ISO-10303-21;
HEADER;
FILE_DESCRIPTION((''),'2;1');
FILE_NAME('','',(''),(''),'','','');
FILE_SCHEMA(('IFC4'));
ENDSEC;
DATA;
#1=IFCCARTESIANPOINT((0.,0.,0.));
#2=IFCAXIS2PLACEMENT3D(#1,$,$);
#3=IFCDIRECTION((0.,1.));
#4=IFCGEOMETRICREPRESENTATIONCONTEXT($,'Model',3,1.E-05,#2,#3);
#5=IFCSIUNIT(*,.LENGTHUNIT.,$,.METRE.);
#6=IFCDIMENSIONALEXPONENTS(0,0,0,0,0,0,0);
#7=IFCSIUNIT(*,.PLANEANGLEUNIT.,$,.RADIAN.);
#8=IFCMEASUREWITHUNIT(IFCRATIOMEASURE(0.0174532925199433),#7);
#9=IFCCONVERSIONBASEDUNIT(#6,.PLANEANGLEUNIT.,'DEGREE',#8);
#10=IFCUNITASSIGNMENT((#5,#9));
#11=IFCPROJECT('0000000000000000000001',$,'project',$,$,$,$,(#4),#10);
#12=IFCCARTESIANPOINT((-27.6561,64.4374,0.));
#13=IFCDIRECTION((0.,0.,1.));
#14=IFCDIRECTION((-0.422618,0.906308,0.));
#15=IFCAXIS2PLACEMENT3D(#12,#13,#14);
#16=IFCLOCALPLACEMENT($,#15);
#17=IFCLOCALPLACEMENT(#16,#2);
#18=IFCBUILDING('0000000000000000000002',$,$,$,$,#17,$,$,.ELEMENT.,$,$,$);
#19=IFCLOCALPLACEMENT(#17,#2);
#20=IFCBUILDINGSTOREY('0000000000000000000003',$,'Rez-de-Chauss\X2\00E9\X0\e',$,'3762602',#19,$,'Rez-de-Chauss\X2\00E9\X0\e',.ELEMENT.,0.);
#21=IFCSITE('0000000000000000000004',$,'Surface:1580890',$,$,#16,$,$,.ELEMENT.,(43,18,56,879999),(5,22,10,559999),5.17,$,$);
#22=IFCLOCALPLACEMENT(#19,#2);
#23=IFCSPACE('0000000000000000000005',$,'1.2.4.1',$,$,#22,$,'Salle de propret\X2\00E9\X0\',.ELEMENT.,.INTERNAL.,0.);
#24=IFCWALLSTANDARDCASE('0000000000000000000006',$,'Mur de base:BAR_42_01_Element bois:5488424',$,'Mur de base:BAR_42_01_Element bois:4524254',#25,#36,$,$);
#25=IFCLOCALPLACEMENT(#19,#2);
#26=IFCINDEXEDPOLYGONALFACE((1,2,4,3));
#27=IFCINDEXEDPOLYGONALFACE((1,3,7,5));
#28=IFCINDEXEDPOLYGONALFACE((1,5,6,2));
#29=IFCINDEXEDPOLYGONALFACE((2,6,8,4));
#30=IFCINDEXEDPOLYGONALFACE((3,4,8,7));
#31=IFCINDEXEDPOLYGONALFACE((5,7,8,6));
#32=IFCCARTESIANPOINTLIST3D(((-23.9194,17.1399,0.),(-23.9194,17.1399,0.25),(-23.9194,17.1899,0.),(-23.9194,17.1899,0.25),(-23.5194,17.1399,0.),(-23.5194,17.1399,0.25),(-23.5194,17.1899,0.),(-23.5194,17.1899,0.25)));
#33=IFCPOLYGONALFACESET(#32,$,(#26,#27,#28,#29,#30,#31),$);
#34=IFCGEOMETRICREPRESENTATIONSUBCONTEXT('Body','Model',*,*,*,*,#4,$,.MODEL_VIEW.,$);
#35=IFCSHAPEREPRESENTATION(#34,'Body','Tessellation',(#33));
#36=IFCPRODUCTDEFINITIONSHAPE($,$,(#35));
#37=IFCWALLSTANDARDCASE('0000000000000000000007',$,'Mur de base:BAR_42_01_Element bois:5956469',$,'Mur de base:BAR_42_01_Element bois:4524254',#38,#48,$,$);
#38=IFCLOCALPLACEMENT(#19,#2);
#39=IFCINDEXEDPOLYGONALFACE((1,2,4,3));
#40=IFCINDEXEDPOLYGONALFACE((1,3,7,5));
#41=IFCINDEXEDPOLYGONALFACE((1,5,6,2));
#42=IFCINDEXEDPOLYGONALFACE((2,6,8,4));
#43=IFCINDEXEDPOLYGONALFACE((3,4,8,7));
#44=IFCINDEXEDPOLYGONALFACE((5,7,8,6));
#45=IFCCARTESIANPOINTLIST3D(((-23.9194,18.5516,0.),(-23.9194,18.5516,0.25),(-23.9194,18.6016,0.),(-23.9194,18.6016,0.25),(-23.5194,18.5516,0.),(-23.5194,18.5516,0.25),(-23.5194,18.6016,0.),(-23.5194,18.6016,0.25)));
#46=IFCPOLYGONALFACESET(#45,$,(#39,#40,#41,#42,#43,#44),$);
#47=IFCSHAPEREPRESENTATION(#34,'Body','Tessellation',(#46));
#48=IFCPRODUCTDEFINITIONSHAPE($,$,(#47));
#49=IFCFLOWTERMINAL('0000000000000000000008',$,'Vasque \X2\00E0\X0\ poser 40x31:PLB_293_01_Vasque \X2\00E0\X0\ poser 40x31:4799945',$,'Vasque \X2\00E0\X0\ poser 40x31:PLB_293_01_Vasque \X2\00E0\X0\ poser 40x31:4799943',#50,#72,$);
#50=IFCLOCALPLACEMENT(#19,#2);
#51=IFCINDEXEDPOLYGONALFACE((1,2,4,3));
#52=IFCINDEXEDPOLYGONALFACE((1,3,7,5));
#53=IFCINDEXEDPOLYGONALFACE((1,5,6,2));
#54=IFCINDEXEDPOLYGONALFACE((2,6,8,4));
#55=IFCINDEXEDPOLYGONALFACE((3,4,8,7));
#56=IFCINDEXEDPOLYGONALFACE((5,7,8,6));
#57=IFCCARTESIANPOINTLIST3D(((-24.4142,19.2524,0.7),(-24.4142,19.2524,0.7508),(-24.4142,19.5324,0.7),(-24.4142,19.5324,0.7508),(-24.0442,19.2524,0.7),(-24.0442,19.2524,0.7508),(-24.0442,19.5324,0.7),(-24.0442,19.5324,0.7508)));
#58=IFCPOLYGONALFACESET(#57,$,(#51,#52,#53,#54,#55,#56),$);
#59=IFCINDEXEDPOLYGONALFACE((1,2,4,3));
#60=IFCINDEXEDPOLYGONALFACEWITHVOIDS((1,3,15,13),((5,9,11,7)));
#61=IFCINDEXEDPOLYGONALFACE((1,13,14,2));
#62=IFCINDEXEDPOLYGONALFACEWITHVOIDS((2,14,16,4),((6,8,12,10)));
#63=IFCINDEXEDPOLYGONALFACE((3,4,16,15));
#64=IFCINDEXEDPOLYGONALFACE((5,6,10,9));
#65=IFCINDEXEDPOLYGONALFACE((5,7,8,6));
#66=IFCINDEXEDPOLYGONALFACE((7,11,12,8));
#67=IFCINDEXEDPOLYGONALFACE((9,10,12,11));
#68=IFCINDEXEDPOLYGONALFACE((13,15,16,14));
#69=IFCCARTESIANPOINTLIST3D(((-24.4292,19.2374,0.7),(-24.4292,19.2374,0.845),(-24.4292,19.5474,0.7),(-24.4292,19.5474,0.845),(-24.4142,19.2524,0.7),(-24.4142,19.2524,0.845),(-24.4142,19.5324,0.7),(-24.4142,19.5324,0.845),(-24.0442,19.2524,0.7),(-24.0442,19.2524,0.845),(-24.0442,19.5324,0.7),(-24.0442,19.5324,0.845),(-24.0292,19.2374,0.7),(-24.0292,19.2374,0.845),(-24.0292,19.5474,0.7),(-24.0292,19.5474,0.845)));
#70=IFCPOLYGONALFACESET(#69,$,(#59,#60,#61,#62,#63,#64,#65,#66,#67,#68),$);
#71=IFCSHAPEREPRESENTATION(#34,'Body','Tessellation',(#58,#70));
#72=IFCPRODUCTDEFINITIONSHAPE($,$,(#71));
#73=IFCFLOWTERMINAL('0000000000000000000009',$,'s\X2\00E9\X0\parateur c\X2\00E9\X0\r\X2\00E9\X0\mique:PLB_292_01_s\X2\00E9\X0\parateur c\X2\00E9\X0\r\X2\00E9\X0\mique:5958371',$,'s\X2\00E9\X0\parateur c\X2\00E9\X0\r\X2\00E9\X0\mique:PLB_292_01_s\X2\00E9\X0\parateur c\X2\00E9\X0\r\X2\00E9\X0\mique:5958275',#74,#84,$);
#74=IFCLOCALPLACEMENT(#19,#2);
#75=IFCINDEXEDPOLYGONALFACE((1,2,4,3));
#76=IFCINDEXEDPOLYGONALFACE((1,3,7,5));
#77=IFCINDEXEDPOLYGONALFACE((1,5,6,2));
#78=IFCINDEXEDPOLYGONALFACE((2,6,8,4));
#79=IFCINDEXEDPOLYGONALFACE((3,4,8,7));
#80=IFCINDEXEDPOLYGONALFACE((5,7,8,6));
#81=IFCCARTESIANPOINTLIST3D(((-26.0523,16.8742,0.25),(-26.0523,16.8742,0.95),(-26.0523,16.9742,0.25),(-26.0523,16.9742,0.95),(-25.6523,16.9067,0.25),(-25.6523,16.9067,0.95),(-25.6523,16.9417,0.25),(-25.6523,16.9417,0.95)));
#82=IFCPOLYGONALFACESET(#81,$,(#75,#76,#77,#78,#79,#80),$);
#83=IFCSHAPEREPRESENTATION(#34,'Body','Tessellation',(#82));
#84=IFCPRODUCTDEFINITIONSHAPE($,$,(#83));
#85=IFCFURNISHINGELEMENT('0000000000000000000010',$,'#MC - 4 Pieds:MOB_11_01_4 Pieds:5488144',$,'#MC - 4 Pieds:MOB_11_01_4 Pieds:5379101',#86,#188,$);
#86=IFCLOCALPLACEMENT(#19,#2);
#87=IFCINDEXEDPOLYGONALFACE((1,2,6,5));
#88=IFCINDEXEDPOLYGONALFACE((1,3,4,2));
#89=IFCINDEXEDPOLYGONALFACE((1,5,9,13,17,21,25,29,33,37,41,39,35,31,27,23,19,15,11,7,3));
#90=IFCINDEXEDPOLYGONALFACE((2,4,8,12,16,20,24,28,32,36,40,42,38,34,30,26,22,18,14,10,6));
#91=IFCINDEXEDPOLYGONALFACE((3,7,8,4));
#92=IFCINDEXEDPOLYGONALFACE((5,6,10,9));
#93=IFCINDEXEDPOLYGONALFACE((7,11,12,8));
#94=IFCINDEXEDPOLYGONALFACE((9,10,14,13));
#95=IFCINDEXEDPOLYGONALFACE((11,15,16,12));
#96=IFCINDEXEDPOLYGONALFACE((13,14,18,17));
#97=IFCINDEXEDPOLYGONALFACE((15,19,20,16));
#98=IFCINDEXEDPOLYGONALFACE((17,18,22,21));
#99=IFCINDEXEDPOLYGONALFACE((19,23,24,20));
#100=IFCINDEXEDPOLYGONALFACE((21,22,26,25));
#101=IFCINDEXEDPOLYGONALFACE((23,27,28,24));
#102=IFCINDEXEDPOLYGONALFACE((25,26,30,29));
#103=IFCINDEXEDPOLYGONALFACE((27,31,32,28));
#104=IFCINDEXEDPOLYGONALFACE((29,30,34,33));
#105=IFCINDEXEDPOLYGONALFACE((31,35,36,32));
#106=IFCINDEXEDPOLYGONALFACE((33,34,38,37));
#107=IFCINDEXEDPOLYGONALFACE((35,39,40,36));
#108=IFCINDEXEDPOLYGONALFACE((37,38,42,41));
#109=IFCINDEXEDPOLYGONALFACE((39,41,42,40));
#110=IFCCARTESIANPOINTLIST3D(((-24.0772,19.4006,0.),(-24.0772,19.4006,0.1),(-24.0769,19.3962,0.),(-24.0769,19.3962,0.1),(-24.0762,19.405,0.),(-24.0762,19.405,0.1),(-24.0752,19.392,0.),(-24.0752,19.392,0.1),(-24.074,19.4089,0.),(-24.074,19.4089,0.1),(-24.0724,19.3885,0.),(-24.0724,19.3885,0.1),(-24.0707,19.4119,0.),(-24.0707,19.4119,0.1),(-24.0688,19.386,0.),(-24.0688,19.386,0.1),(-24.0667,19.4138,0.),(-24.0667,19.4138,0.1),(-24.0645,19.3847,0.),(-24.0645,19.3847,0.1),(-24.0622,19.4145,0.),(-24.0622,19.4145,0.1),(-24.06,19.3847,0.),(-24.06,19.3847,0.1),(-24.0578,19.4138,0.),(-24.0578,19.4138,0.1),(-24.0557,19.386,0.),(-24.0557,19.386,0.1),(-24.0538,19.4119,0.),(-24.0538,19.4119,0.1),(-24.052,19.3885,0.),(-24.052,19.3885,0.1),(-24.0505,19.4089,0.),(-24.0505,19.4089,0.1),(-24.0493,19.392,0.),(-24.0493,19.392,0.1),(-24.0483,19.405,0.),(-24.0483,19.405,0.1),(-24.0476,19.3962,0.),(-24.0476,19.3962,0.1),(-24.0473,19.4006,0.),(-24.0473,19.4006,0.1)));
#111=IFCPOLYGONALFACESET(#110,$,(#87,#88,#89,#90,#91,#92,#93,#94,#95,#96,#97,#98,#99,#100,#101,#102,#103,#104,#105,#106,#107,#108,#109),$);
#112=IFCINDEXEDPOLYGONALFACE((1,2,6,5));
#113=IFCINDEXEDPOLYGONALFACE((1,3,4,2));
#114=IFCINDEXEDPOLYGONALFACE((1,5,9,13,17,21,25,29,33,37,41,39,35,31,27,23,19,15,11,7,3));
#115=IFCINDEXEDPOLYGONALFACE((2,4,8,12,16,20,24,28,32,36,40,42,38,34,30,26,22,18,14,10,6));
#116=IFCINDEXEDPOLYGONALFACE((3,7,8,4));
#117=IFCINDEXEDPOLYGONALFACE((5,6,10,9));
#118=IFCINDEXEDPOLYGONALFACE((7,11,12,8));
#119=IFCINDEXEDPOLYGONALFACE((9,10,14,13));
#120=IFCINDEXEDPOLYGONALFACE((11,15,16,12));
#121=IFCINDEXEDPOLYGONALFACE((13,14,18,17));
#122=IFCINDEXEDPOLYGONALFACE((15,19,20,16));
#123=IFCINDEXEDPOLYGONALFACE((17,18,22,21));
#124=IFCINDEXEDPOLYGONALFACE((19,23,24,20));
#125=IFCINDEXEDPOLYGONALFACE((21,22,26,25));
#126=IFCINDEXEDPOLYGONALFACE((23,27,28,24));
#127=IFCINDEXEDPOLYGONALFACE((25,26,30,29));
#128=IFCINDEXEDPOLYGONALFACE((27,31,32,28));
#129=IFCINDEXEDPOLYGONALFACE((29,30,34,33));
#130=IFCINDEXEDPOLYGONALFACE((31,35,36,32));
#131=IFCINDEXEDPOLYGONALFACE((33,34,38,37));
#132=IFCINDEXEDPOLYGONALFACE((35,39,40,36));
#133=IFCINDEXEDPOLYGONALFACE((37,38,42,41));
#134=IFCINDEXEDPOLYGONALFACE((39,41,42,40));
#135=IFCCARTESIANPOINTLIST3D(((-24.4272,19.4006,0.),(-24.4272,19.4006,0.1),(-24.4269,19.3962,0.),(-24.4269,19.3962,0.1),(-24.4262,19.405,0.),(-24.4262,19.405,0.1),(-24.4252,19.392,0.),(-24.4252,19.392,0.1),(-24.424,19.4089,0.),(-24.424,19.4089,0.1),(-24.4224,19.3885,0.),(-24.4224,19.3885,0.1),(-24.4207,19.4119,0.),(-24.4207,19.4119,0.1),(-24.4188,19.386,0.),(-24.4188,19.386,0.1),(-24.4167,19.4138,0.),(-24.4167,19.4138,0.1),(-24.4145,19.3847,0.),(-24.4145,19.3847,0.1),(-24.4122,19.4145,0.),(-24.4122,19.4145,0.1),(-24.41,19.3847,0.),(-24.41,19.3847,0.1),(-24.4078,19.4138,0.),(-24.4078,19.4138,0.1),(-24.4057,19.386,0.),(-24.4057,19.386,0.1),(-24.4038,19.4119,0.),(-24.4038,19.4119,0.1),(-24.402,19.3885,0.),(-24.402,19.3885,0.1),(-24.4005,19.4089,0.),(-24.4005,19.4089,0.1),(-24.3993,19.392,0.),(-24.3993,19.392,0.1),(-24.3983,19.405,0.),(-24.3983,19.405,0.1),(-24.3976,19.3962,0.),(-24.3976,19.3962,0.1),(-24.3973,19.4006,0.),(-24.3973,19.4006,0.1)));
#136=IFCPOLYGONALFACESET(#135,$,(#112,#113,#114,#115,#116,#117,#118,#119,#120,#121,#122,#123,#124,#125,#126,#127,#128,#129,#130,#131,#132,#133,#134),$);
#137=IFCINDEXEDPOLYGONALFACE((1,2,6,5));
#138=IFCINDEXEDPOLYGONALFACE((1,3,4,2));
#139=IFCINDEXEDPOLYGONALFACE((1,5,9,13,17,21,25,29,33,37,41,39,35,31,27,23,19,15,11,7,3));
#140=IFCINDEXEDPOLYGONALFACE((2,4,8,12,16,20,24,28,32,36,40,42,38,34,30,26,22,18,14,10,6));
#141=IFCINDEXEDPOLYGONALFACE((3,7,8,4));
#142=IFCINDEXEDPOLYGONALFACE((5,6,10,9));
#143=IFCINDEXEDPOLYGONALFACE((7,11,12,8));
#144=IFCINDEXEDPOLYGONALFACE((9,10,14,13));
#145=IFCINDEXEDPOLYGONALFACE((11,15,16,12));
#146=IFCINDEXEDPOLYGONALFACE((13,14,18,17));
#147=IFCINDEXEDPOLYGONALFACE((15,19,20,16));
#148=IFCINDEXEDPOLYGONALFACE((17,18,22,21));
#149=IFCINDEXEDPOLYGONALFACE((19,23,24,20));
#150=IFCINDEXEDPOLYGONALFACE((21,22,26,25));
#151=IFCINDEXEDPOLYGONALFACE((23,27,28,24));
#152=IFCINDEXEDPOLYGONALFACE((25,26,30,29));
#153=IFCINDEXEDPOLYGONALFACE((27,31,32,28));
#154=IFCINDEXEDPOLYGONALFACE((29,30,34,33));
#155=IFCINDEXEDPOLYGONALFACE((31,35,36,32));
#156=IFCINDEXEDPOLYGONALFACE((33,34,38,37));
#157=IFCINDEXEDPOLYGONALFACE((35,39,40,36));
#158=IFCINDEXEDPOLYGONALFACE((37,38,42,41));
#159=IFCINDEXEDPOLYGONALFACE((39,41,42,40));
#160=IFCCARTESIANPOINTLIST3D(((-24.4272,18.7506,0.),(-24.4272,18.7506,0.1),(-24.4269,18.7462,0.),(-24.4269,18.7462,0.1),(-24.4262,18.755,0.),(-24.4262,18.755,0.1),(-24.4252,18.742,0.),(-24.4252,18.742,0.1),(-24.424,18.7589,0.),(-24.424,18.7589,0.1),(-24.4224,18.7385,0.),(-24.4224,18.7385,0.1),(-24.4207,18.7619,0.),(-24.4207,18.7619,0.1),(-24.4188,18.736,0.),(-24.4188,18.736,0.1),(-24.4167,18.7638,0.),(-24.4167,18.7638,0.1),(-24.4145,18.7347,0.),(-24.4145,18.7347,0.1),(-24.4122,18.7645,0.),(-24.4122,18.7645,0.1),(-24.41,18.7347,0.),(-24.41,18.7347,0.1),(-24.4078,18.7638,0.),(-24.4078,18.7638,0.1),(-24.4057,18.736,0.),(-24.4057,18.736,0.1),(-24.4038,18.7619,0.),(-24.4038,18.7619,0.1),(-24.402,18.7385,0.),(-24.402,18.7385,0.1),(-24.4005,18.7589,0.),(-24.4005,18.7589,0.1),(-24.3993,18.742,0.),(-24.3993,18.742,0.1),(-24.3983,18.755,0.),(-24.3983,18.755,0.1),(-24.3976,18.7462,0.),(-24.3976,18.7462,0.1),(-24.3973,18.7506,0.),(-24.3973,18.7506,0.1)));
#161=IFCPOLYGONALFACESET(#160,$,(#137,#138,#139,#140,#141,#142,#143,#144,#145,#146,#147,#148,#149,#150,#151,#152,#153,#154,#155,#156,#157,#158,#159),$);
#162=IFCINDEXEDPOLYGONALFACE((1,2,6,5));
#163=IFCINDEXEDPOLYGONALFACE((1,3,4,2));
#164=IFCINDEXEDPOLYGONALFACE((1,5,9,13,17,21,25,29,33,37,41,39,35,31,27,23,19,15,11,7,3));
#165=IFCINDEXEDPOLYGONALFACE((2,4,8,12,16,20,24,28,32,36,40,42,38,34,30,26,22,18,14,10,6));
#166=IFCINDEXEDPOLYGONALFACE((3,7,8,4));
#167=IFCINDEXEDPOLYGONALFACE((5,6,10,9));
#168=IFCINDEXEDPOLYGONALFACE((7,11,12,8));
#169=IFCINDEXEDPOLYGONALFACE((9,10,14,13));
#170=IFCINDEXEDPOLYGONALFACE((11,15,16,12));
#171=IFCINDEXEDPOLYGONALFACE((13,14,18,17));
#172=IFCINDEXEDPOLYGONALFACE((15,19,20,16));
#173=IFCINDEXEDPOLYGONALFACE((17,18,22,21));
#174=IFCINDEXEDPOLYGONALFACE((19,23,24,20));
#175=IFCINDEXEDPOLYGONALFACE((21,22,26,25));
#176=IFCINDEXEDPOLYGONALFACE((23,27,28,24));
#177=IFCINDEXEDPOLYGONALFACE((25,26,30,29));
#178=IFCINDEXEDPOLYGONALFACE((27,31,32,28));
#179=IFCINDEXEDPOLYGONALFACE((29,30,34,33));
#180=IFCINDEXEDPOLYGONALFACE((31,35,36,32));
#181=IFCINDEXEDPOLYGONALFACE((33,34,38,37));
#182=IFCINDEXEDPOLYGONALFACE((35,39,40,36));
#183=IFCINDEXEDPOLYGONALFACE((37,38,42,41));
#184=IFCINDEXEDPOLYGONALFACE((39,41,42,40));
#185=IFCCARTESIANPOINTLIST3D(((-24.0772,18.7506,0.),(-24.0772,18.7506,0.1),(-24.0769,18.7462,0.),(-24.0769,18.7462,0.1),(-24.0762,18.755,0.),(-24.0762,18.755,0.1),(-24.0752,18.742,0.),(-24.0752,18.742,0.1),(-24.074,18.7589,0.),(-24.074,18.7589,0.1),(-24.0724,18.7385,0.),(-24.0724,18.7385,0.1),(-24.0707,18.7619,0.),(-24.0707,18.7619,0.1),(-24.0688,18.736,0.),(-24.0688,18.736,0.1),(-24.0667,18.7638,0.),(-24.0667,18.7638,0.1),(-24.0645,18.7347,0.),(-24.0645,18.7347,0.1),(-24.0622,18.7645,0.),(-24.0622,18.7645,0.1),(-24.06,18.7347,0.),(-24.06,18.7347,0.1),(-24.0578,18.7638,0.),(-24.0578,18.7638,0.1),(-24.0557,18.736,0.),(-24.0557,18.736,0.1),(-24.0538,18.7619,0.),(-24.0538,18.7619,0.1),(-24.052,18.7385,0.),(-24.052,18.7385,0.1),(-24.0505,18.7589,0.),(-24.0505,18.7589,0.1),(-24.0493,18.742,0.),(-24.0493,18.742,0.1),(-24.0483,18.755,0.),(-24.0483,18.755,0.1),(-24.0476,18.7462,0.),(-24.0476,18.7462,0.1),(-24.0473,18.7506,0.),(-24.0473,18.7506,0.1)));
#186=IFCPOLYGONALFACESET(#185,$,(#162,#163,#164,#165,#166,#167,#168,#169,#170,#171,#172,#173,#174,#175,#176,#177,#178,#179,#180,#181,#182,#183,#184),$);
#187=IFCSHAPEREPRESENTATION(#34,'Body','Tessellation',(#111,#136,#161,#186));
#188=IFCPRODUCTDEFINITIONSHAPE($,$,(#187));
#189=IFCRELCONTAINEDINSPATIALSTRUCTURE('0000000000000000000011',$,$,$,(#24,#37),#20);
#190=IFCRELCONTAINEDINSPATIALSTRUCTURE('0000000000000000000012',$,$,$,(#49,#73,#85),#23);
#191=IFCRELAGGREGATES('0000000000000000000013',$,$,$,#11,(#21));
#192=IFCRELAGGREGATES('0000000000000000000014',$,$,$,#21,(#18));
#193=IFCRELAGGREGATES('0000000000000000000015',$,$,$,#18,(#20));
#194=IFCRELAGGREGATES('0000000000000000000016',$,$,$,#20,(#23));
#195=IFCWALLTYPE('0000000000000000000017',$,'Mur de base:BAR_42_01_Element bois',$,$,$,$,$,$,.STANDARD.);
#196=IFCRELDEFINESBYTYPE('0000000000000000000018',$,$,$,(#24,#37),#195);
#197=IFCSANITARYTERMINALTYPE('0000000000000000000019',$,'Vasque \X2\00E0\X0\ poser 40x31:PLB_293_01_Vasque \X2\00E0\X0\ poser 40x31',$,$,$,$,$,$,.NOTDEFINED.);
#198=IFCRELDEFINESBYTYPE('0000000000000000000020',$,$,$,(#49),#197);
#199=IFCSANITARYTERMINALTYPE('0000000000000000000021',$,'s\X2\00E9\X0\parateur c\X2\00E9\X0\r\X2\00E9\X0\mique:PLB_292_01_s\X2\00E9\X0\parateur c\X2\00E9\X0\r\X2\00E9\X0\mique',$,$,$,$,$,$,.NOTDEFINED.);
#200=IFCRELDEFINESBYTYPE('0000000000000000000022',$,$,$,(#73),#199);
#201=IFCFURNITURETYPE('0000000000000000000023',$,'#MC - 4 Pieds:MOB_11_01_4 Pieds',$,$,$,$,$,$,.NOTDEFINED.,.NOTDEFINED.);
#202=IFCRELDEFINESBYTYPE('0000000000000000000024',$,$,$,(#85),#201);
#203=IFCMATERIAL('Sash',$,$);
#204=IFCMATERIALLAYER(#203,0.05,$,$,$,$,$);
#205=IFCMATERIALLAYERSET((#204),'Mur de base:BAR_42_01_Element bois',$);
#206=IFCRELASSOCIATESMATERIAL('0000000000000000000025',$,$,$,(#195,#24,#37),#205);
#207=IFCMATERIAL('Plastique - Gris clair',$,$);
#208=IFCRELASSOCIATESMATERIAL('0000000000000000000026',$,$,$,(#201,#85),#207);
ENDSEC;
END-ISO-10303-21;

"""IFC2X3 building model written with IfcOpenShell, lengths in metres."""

from ifc_helpers import new_model, entity, si_unit, converted_unit, direction, frame, frame_2d, origin, origin_2d_with_axis, place, context, subcontext, project, spatial, polyline, rectangle, circle, outline, extrude, source, transform, mapped, material, layer, layer_set, layer_usage, type_object, type_shapes, element, save


model = new_model("IFC2X3")

# Units and contexts
model_context = context("Model", 3, precision=1e-05, world=origin(), true_north=direction((0.0, 1.0)))
body_context = subcontext(model_context, "Body", "Model", "MODEL_VIEW")
ifc_project = project(units=[si_unit("LENGTHUNIT", "METRE"), converted_unit("PLANEANGLEUNIT", "DEGREE", entity("IfcRatioMeasure", 0.0174532925199433), si_unit("PLANEANGLEUNIT", "RADIAN"), dimensions=[0, 0, 0, 0, 0, 0, 0])], contexts=[model_context])

# Site, building, storey
site_placement = place(None, frame((-27.6561, 64.4374, 0.0), z_axis=(0.0, 0.0, 1.0), x_axis=(-0.422618, 0.906308, 0.0)))
site = spatial("IfcSite", under=ifc_project, at=site_placement, Name="Surface:1580890", CompositionType="ELEMENT", RefLatitude=(43, 18, 56, 879999), RefLongitude=(5, 22, 10, 559999), RefElevation=5.17)
building_placement = place(site_placement, origin())
building = spatial("IfcBuilding", under=site, at=building_placement, CompositionType="ELEMENT")
storey_placement = place(building_placement, origin())
storey = spatial("IfcBuildingStorey", under=building, at=storey_placement, Name="Rez-de-Chaussée", ObjectType="3762602", LongName="Rez-de-Chaussée", CompositionType="ELEMENT", Elevation=0.0)

# Walls
ifc_material_1 = material(Name="Sash")
ifc_layer = layer(ifc_material_1, 0.05)
ifc_layer_set = layer_set([ifc_layer], Name="Mur de base:BAR_42_01_Element bois")
ifc_layer_usage_1 = layer_usage(ifc_layer_set, "AXIS2", "POSITIVE", -0.025)
wall_type = type_object("IfcWallType", Name="Mur de base:BAR_42_01_Element bois", PredefinedType="STANDARD", material=ifc_layer_set)
wall_1_placement = place(storey_placement, frame((-23.9194, 17.1649, 0.0)))
element("IfcWallStandardCase", 1, at=wall_1_placement, inside=storey, type_object=wall_type, material=ifc_layer_usage_1, Name="Mur de base:BAR_42_01_Element bois:5488424", ObjectType="Mur de base:BAR_42_01_Element bois:4524254", context=body_context, shape_type="SweptSolid", body=[
    extrude(rectangle(XDim=0.4, YDim=0.05, at=frame_2d((0.2, 0.0), x_axis=(-1.0, 0.0))), origin(), (0.0, 0.0, 1.0), 0.25),
])
ifc_layer_usage_2 = layer_usage(ifc_layer_set, "AXIS2", "POSITIVE", -0.025)
wall_2_placement = place(storey_placement, frame((-23.9194, 18.5766, 0.0)))
element("IfcWallStandardCase", 2, at=wall_2_placement, inside=storey, type_object=wall_type, material=ifc_layer_usage_2, Name="Mur de base:BAR_42_01_Element bois:5956469", ObjectType="Mur de base:BAR_42_01_Element bois:4524254", context=body_context, shape_type="SweptSolid", body=[
    extrude(rectangle(XDim=0.4, YDim=0.05, at=frame_2d((0.2, 0.0), x_axis=(-1.0, 0.0))), origin(), (0.0, 0.0, 1.0), 0.25),
])

# Shared definitions
space_placement = place(storey_placement, origin())
space = spatial("IfcSpace", under=storey, at=space_placement, Name="1.2.4.1", LongName="Salle de propreté", CompositionType="ELEMENT", InteriorOrExteriorSpace="INTERNAL", ElevationWithFlooring=0.0)

# Flow terminals
sanitary_terminal_type_1 = type_object("IfcSanitaryTerminalType", Name="Vasque à poser 40x31:PLB_293_01_Vasque à poser 40x31", PredefinedType="NOTDEFINED")
shared_shape_1 = source(origin(), body_context, "Body", "SweptSolid", [
    extrude(rectangle(XDim=0.37, YDim=0.28, at=frame_2d((0.0, 0.0), x_axis=(1.0, 0.0))), frame((-0.1048, -0.155, 0.0), z_axis=(0.0, 0.0, 1.0), x_axis=(-1.0, 0.0, 0.0)), (0.0, 0.0, 1.0), 0.0508),
    extrude(outline(polyline([(-0.2, -0.155), (0.2, -0.155), (0.2, 0.155), (-0.2, 0.155), (-0.2, -0.155)]), holes=[polyline([(0.185, -0.14), (-0.185, -0.14), (-0.185, 0.14), (0.185, 0.14), (0.185, -0.14)])]), frame((-0.1048, -0.155, 0.0), z_axis=(0.0, 0.0, 1.0), x_axis=(-1.0, 0.0, 0.0)), (0.0, 0.0, 1.0), 0.145),
])
type_shapes(sanitary_terminal_type_1, [shared_shape_1])
flow_terminal_1_placement = place(space_placement, frame((-24.1244, 19.5474, 0.7)))
element("IfcFlowTerminal", 3, at=flow_terminal_1_placement, inside=space, type_object=sanitary_terminal_type_1, Name="Vasque à poser 40x31:PLB_293_01_Vasque à poser 40x31:4799945", ObjectType="Vasque à poser 40x31:PLB_293_01_Vasque à poser 40x31:4799943", context=body_context, shape_type="MappedRepresentation", body=[
    mapped(shared_shape_1, transform((0.0, 0.0, 0.0), scale=1.0)),
])
sanitary_terminal_type_2 = type_object("IfcSanitaryTerminalType", Name="séparateur cérémique:PLB_292_01_séparateur cérémique", PredefinedType="NOTDEFINED")
shared_shape_2 = source(origin(), body_context, "Body", "SweptSolid", [
    extrude(outline(polyline([(-0.05, -0.2), (0.05, -0.2), (0.0175, 0.2), (-0.0175, 0.2), (-0.05, -0.2)])), frame((0.0, 0.0, 0.25), z_axis=(0.0, 0.0, 1.0), x_axis=(0.0, -1.0, 0.0)), (0.0, 0.0, 1.0), 0.7),
])
type_shapes(sanitary_terminal_type_2, [shared_shape_2])
flow_terminal_2_placement = place(space_placement, frame((-25.8523, 16.9242, 0.0)))
element("IfcFlowTerminal", 4, at=flow_terminal_2_placement, inside=space, type_object=sanitary_terminal_type_2, Name="séparateur cérémique:PLB_292_01_séparateur cérémique:5958371", ObjectType="séparateur cérémique:PLB_292_01_séparateur cérémique:5958275", context=body_context, shape_type="MappedRepresentation", body=[
    mapped(shared_shape_2, transform((0.0, 0.0, 0.0), scale=1.0)),
])

# Furnishing element
ifc_material_2 = material(Name="Plastique - Gris clair")
furniture_type_1 = type_object("IfcFurnitureType", Name="#MC - 4 Pieds:MOB_11_01_4 Pieds", material=ifc_material_2)
shared_shape_3 = source(origin(), body_context, "Body", "SweptSolid", [
    extrude(circle(Radius=0.015, at=frame_2d((0.0, 0.0), x_axis=(1.0, 0.0))), frame((0.3303, 0.15, 0.0)), (0.0, 0.0, 1.0), 0.1),
    extrude(circle(Radius=0.015, at=origin_2d_with_axis()), frame((0.3303, 0.5, 0.0)), (0.0, 0.0, 1.0), 0.1),
    extrude(circle(Radius=0.015, at=frame_2d((0.0, 0.0), x_axis=(1.0, 0.0))), frame((-0.3197, 0.5, 0.0)), (0.0, 0.0, 1.0), 0.1),
    extrude(circle(Radius=0.015, at=frame_2d((0.0, 0.0), x_axis=(1.0, 0.0))), frame((-0.3197, 0.15, 0.0)), (0.0, 0.0, 1.0), 0.1),
])
type_shapes(furniture_type_1, [shared_shape_3])
for number, where, z_axis, x_axis, name in (
    (5, (-23.9122, 19.0692, 0.0), (0.0, 0.0, 1.0), (0.0, 1.0, 0.0), "#MC - 4 Pieds:MOB_11_01_4 Pieds:5488144"),
):
    element("IfcFurnishingElement", number, at=place(space_placement, frame(where, z_axis=z_axis, x_axis=x_axis)), inside=space, type_object=furniture_type_1, material=ifc_material_2, Name=name, ObjectType="#MC - 4 Pieds:MOB_11_01_4 Pieds:5379101", context=body_context, shape_type="MappedRepresentation", body=[
        mapped(shared_shape_3, transform((0.0, 0.0, 0.0), scale=1.0)),
    ])

save(model, "model.ifc")
